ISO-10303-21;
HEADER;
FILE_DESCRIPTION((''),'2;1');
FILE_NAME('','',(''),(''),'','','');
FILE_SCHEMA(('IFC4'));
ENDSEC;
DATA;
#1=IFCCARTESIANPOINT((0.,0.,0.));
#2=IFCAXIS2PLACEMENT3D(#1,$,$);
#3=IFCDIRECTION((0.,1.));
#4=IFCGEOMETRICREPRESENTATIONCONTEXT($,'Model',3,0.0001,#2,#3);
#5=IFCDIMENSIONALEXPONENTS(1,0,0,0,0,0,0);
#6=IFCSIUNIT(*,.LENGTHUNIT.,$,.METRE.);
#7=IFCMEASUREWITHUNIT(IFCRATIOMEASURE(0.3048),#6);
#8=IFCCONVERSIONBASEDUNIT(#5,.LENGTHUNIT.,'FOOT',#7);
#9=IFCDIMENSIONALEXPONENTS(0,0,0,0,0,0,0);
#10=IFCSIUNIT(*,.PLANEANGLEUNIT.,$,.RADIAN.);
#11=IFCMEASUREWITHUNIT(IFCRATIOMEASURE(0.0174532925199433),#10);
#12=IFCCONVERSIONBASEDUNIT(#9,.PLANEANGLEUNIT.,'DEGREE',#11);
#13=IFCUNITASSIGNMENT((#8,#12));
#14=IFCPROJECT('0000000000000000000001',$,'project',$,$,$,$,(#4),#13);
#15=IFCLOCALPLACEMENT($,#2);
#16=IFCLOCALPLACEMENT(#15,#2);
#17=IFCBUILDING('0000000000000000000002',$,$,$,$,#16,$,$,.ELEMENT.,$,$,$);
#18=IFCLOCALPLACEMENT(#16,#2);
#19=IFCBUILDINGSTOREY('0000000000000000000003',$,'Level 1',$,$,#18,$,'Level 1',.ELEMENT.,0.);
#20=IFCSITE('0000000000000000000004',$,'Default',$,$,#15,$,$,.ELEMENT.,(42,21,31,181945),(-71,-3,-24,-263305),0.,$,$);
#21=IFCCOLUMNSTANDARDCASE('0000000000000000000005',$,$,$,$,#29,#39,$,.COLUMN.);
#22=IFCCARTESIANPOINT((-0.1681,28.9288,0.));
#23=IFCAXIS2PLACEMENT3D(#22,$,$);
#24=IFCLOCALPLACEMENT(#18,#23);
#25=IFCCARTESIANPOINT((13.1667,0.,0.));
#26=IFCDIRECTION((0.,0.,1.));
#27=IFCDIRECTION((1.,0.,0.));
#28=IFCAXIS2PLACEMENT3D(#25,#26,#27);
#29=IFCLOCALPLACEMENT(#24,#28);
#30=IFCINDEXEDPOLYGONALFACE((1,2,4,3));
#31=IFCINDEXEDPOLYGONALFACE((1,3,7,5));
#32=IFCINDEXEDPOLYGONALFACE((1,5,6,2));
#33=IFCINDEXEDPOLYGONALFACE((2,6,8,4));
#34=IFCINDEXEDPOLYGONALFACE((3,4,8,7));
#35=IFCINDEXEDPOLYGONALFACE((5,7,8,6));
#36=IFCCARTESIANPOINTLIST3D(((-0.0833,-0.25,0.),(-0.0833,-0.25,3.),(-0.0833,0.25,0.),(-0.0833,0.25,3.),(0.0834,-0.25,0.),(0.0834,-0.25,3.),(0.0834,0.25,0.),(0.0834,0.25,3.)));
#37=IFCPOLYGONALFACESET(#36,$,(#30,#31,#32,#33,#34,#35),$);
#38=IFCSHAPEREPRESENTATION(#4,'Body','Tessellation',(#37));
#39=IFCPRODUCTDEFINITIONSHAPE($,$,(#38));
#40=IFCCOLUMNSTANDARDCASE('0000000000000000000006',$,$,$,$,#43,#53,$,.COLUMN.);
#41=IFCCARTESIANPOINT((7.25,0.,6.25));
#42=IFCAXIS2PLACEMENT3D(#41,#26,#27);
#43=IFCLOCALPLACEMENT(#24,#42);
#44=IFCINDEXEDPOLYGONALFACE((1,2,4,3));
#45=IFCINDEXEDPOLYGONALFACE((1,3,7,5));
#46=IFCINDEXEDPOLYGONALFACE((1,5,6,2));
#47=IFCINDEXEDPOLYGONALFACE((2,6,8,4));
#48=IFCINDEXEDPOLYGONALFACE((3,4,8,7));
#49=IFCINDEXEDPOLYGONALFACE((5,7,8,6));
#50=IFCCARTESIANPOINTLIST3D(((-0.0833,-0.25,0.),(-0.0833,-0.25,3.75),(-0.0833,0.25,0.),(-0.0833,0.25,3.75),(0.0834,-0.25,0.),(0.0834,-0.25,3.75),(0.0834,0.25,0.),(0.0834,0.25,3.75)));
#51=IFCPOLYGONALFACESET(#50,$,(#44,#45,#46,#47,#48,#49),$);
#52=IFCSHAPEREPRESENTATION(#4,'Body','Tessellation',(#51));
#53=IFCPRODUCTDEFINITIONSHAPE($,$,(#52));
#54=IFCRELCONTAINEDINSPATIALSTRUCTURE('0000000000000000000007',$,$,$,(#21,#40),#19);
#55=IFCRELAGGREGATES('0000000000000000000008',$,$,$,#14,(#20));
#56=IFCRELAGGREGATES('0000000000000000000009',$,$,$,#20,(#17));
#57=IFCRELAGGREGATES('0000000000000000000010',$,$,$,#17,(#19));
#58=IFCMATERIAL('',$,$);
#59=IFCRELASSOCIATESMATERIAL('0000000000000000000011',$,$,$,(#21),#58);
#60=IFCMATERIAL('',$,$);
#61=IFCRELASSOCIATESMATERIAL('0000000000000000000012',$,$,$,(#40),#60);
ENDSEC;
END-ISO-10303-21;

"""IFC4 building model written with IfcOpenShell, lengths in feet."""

from ifc_helpers import new_model, entity, si_unit, converted_unit, direction, frame, origin, place, context, project, spatial, rectangle, extrude, material, element, save


model = new_model("IFC4")

# Units and contexts
model_context = context("Model", 3, precision=0.0001, world=origin(), true_north=direction((0.0, 1.0)))
ifc_project = project(units=[converted_unit("LENGTHUNIT", "FOOT", entity("IfcRatioMeasure", 0.3048), si_unit("LENGTHUNIT", "METRE"), dimensions=[1, 0, 0, 0, 0, 0, 0]), converted_unit("PLANEANGLEUNIT", "DEGREE", entity("IfcRatioMeasure", 0.0174532925199433), si_unit("PLANEANGLEUNIT", "RADIAN"), dimensions=[0, 0, 0, 0, 0, 0, 0])], contexts=[model_context])

# Site, building, storey
site_placement = place(None, origin())
site = spatial("IfcSite", under=ifc_project, at=site_placement, Name="Default", CompositionType="ELEMENT", RefLatitude=(42, 21, 31, 181945), RefLongitude=(-71, -3, -24, -263305), RefElevation=0.0)
building_placement = place(site_placement, origin())
building = spatial("IfcBuilding", under=site, at=building_placement, CompositionType="ELEMENT")
storey_placement = place(building_placement, origin())
storey = spatial("IfcBuildingStorey", under=building, at=storey_placement, Name="Level 1", LongName="Level 1", CompositionType="ELEMENT", Elevation=0.0)

# Columns
ifc_material_1 = material(Name="")
placement = place(storey_placement, frame((-0.1681, 28.9288, 0.0)))
for number, where, z_axis, x_axis in (
    (1, (13.1667, 0.0, 0.0), (0.0, 0.0, 1.0), (1.0, 0.0, 0.0)),
):
    element("IfcColumnStandardCase", number, at=place(placement, frame(where, z_axis=z_axis, x_axis=x_axis)), inside=storey, material=ifc_material_1, PredefinedType="COLUMN", context=model_context, shape_type="SweptSolid", body=[
        extrude(rectangle(XDim=0.1667, YDim=0.5), origin(), (0.0, 0.0, 1.0), 3.0),
    ])
ifc_material_2 = material(Name="")
for number, where, z_axis, x_axis in (
    (2, (7.25, 0.0, 6.25), (0.0, 0.0, 1.0), (1.0, 0.0, 0.0)),
):
    element("IfcColumnStandardCase", number, at=place(placement, frame(where, z_axis=z_axis, x_axis=x_axis)), inside=storey, material=ifc_material_2, PredefinedType="COLUMN", context=model_context, shape_type="SweptSolid", body=[
        extrude(rectangle(XDim=0.1667, YDim=0.5), origin(), (0.0, 0.0, 1.0), 3.75),
    ])

save(model, "model.ifc")
